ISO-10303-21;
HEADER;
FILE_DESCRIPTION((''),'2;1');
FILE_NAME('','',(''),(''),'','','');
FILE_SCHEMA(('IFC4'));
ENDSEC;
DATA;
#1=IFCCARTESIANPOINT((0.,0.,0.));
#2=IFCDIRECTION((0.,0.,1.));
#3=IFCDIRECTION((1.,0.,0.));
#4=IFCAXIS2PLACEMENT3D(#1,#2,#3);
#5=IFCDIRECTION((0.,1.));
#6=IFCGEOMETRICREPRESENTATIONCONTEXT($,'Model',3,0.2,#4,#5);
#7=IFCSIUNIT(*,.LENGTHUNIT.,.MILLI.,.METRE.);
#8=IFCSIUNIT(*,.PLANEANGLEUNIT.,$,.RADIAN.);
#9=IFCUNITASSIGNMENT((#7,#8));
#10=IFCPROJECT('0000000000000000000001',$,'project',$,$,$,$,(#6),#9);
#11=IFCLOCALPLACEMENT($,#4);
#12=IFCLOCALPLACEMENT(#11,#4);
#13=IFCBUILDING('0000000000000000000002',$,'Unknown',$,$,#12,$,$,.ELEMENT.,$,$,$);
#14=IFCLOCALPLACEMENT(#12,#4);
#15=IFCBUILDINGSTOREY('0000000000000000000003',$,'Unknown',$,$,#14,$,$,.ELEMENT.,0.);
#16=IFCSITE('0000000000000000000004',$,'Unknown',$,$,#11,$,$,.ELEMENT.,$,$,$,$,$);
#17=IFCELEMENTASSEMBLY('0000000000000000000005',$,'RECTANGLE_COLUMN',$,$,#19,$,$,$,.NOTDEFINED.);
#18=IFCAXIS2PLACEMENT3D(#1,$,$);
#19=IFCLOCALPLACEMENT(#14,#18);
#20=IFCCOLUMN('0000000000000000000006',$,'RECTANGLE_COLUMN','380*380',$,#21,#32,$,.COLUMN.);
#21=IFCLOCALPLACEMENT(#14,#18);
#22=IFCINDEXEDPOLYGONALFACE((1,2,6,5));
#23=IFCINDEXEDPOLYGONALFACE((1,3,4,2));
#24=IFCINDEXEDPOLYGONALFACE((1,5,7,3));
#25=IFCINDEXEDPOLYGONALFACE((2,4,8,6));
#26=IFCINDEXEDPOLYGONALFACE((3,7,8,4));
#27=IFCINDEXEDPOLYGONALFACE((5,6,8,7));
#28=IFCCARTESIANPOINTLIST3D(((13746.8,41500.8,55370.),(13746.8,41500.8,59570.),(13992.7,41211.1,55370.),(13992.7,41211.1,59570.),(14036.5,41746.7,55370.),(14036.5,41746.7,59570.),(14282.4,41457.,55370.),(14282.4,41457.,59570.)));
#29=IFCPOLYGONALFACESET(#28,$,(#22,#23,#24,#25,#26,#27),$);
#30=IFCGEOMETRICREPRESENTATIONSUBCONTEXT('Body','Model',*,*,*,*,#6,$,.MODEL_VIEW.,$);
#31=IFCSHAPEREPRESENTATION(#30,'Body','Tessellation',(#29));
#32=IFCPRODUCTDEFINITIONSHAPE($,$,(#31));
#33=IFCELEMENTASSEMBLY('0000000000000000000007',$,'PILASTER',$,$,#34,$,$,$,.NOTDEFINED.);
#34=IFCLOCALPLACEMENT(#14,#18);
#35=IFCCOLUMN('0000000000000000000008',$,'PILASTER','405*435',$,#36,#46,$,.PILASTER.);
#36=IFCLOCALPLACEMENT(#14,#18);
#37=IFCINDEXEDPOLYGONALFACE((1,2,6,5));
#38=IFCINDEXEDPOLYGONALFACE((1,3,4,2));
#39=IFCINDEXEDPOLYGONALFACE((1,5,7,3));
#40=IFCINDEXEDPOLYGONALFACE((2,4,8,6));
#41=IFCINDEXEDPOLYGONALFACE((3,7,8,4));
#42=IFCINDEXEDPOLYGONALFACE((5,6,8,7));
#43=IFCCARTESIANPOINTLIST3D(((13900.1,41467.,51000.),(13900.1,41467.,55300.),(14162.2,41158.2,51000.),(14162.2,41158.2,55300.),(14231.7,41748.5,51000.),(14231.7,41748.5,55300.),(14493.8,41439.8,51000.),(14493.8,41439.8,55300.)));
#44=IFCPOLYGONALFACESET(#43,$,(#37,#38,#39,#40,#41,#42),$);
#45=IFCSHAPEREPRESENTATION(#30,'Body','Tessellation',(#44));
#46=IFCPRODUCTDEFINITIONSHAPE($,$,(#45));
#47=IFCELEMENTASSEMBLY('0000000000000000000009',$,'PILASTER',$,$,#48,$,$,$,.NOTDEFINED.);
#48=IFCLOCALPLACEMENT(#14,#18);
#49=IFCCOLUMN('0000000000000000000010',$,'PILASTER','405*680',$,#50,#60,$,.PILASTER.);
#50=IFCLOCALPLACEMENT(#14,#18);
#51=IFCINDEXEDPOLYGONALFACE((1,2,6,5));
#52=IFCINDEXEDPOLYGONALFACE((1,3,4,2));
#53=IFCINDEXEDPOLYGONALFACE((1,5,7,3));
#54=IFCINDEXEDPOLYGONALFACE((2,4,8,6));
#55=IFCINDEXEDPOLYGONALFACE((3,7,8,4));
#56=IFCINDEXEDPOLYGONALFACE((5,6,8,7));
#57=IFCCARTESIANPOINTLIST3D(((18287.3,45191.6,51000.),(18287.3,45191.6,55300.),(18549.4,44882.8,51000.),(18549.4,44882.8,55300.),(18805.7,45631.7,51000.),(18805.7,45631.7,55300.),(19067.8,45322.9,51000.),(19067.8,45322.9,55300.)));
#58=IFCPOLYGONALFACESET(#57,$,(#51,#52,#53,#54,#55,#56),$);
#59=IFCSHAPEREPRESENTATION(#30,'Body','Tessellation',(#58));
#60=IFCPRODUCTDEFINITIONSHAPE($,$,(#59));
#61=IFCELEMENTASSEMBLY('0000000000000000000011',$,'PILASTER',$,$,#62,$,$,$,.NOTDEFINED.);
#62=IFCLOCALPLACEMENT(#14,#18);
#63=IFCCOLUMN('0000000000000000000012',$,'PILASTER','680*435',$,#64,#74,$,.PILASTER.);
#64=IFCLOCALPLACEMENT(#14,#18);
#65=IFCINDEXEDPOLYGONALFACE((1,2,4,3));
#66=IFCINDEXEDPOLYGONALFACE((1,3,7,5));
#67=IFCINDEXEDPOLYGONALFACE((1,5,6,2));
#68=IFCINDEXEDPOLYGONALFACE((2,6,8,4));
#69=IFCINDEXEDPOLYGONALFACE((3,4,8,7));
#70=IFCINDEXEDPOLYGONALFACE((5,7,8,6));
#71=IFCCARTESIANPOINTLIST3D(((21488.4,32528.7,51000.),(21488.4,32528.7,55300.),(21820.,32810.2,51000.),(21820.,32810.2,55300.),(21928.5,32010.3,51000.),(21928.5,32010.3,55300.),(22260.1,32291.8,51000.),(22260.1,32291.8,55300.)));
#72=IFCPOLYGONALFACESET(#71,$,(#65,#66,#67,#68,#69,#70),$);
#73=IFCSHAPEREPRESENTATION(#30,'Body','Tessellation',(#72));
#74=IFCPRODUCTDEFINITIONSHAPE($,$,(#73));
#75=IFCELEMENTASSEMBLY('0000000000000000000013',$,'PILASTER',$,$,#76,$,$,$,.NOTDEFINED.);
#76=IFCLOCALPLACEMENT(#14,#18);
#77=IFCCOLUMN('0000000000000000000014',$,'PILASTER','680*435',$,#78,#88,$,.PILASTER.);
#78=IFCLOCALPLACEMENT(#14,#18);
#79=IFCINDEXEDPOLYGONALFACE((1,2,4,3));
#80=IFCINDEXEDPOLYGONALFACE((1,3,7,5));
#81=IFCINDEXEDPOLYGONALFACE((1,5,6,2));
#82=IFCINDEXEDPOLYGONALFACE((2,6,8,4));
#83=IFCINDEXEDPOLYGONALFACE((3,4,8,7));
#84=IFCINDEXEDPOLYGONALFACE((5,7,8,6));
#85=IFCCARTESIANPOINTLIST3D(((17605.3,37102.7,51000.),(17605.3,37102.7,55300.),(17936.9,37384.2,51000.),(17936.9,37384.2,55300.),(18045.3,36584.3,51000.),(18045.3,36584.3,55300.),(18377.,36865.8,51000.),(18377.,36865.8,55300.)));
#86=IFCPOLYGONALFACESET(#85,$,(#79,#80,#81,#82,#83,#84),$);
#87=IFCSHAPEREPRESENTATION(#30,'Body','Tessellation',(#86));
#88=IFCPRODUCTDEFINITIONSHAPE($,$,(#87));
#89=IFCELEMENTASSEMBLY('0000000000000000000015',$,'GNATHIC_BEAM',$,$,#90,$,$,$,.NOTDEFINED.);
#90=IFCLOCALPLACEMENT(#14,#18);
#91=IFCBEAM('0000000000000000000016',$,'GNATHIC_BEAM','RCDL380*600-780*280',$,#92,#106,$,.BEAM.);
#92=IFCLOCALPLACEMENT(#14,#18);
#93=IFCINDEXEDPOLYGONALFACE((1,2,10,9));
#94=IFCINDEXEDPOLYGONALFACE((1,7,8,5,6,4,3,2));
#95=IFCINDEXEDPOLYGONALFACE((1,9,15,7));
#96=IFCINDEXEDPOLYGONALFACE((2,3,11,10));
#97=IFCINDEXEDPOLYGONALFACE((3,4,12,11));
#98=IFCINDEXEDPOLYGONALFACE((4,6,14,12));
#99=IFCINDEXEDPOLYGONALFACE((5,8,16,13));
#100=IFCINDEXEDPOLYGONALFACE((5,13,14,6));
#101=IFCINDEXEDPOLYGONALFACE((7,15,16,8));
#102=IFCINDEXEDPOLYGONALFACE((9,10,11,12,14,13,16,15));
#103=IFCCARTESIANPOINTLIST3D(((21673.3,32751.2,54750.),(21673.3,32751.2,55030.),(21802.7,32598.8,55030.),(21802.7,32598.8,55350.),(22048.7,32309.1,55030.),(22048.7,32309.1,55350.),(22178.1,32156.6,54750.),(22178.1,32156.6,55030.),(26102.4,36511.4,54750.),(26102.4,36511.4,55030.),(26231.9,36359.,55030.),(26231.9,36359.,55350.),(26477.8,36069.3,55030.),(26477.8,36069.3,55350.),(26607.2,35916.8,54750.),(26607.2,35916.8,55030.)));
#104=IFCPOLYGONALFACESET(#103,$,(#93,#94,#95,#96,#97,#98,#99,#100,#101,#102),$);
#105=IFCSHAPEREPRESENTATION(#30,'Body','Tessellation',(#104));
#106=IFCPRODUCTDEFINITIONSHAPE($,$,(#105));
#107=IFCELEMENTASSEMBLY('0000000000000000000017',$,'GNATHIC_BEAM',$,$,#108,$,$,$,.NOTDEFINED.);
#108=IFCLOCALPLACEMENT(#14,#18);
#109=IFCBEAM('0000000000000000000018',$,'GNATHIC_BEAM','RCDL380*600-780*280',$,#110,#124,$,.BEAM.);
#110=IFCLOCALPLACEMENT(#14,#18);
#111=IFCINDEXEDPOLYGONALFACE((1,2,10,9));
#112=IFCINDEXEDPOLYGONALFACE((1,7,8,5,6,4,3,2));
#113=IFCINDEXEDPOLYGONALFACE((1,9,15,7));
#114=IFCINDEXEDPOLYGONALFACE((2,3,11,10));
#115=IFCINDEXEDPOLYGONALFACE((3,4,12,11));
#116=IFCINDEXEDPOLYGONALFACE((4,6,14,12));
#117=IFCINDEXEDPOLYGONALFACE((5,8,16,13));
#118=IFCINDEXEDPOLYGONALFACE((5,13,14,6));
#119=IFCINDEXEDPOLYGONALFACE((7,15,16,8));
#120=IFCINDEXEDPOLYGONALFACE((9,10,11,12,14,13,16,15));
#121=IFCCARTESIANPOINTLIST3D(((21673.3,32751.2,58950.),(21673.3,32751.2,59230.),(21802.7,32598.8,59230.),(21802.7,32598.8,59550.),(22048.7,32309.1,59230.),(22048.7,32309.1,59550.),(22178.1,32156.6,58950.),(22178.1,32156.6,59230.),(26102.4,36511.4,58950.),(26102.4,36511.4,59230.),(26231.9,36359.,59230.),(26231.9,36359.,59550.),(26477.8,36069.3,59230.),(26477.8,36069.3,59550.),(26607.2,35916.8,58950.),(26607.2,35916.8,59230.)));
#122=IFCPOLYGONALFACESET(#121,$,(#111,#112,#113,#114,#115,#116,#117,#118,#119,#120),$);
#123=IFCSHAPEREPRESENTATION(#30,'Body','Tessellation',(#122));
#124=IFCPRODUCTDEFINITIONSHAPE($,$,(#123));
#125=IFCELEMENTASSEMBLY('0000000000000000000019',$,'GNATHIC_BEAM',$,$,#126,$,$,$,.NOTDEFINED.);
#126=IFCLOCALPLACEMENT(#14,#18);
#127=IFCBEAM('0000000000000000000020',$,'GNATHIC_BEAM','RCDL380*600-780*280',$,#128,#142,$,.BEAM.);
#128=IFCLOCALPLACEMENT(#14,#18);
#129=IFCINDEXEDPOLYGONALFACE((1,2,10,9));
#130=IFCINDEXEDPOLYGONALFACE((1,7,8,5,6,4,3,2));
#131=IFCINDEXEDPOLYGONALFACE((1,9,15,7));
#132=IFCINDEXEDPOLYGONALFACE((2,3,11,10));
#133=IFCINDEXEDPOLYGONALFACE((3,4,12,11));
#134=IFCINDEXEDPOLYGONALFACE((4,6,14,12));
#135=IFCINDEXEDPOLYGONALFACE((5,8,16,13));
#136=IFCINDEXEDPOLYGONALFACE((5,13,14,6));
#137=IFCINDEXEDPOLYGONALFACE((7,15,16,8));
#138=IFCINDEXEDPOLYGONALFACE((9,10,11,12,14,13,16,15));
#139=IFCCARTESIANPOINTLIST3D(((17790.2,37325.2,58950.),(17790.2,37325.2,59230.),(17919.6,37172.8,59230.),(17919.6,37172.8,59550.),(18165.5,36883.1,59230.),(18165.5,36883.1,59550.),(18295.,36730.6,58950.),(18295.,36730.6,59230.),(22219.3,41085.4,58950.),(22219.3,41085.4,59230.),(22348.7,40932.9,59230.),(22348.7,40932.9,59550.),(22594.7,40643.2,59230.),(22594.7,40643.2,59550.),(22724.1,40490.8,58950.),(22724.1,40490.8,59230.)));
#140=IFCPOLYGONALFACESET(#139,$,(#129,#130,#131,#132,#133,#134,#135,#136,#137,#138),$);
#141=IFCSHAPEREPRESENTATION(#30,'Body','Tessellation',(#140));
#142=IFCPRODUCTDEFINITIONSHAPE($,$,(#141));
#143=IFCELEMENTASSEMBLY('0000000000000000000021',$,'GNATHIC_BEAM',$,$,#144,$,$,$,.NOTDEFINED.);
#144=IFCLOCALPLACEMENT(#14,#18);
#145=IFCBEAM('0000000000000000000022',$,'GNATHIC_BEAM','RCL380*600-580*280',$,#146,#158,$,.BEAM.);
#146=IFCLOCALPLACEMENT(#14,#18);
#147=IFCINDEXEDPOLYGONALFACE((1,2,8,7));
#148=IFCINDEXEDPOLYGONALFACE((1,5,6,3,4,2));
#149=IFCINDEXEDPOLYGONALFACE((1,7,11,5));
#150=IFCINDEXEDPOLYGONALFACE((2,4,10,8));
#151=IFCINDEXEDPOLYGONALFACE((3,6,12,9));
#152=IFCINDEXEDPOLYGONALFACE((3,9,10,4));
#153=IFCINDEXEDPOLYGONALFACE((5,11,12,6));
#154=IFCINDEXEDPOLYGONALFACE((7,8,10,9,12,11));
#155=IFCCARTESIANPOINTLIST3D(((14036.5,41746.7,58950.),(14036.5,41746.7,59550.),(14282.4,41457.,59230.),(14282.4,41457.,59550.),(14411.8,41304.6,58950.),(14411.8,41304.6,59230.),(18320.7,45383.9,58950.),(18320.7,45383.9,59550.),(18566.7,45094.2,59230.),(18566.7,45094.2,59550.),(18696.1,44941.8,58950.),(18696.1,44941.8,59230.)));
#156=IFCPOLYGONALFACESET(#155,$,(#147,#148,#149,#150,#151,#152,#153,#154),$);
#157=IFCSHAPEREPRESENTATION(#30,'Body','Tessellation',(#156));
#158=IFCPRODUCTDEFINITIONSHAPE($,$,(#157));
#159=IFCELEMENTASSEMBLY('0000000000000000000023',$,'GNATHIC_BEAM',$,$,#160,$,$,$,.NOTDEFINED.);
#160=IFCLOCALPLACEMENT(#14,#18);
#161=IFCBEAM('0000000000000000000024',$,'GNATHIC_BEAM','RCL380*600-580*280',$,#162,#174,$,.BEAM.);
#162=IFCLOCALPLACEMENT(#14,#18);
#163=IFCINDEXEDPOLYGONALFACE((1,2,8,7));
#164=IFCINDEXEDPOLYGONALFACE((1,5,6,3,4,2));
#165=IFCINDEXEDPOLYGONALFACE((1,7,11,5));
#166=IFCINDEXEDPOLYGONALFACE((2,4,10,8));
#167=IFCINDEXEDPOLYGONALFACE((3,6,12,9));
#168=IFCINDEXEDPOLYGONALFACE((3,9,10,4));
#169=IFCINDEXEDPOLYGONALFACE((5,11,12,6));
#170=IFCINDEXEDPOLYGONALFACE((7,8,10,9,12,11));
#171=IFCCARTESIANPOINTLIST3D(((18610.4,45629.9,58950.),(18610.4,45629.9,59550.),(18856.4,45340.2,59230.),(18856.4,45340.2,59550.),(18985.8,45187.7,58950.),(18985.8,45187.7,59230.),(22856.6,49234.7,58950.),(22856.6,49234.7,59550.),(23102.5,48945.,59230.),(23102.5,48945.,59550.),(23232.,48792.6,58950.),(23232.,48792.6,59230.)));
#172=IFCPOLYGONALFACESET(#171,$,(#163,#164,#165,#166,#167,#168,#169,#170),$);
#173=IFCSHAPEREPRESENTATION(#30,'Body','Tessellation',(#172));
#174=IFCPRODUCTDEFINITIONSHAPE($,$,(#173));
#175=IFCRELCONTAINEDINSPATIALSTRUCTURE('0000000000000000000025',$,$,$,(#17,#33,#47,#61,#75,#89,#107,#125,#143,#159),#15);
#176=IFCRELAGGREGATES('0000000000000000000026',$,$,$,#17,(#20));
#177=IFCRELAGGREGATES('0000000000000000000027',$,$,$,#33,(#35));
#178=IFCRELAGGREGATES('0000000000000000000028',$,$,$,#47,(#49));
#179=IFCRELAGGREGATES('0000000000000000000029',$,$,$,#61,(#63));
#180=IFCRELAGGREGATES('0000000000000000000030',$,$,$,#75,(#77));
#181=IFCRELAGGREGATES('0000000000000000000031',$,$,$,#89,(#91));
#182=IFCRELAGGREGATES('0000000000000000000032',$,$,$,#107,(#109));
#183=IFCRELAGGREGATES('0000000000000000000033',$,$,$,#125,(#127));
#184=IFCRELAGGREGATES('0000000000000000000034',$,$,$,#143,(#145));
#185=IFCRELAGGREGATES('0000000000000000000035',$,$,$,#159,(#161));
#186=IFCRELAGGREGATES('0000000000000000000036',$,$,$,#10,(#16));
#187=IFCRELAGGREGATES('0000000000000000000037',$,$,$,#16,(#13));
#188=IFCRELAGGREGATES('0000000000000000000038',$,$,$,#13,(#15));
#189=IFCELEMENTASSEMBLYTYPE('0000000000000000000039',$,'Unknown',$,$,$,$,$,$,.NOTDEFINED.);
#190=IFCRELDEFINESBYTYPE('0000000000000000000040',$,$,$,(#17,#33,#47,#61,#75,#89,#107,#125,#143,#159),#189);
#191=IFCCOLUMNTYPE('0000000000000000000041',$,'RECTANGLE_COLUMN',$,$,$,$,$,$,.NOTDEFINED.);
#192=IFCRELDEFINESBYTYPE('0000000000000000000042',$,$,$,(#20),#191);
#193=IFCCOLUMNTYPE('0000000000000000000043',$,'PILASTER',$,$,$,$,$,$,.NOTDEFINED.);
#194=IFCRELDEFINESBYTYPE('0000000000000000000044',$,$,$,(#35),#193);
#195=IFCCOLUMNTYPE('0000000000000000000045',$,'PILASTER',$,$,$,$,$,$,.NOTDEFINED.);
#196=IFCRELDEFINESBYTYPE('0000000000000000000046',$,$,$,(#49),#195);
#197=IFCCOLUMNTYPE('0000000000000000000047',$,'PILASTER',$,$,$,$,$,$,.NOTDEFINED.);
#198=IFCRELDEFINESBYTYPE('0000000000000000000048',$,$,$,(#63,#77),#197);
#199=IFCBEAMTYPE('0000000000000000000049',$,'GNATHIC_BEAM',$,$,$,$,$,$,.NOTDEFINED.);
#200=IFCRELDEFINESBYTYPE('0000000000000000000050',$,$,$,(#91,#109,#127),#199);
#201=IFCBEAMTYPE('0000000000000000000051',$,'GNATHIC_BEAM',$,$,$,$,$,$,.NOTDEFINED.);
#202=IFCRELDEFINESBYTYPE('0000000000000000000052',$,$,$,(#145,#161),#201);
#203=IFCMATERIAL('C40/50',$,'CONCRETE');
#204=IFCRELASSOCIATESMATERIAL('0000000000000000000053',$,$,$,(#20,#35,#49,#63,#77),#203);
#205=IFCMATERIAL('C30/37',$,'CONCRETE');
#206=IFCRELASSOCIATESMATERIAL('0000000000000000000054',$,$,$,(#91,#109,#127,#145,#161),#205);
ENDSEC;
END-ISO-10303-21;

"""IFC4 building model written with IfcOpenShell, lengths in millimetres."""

from ifc_helpers import new_model, si_unit, direction, frame, origin_with_axes, origin_2d_with_axis, place, context, subcontext, project, spatial, polyline, rectangle, outline, extrude, material, material_profile, profile_set, profile_usage, type_object, element, aggregate, save


model = new_model("IFC4")

# Units and contexts
model_context = context("Model", 3, precision=0.2, world=origin_with_axes(), true_north=direction((0.0, 1.0)))
body_context = subcontext(model_context, "Body", "Model", "MODEL_VIEW")
ifc_project = project(units=[si_unit("LENGTHUNIT", "METRE", prefix="MILLI"), si_unit("PLANEANGLEUNIT", "RADIAN")], contexts=[model_context])

# Site, building, storey
site_placement = place(None, origin_with_axes())
site = spatial("IfcSite", under=ifc_project, at=site_placement, Name="Unknown", CompositionType="ELEMENT")
building_placement = place(site_placement, origin_with_axes())
building = spatial("IfcBuilding", under=site, at=building_placement, Name="Unknown", CompositionType="ELEMENT")
storey_placement = place(building_placement, origin_with_axes())
storey = spatial("IfcBuildingStorey", under=building, at=storey_placement, Name="Unknown", CompositionType="ELEMENT", Elevation=0.0)

# Shared definitions
element_assembly_type = type_object("IfcElementAssemblyType", Name="Unknown", PredefinedType="NOTDEFINED")
ifc_material_1 = material(Name="C40/50", Category="CONCRETE")

# Element assemblies, columns
ifc_material_profile_1 = material_profile(ifc_material_1, rectangle(XDim=380.0, YDim=380.0, at=origin_2d_with_axis()), Name="380*380")
ifc_profile_set_1 = profile_set([ifc_material_profile_1])
ifc_profile_usage_1 = profile_usage(ifc_profile_set_1, cardinal=5)
column_type_1 = type_object("IfcColumnType", Name="RECTANGLE_COLUMN")
assembly_1_placement = place(storey_placement, frame((14014.6, 41478.9, 55370.0), z_axis=(-0.762329, -0.64719, 0.0), x_axis=(0.0, 0.0, 1.0)))
assembly_1 = element("IfcElementAssembly", 1, at=assembly_1_placement, inside=storey, type_object=element_assembly_type, Name="RECTANGLE_COLUMN", PredefinedType="NOTDEFINED")
column_1_placement = place(assembly_1_placement, origin_with_axes())
column_1 = element("IfcColumn", 2, at=column_1_placement, type_object=column_type_1, material=ifc_profile_usage_1, Name="RECTANGLE_COLUMN", Description="380*380", PredefinedType="COLUMN", context=body_context, shape_type="SolidModel", body=[
    extrude(rectangle(XDim=380.0, YDim=380.0, at=origin_2d_with_axis()), frame((0.0, 0.0, 0.0), z_axis=(-1.0, 0.0, 0.0), x_axis=(0.0, 0.0, 1.0)), (0.0, 0.0, -1.0), 4200.0),
])
aggregate(assembly_1, [column_1])
assembly_2_placement = place(storey_placement, frame((14197.0, 41453.4, 51000.0), z_axis=(-0.762329, -0.64719, 0.0), x_axis=(0.0, 0.0, 1.0)))
assembly_2 = element("IfcElementAssembly", 3, at=assembly_2_placement, inside=storey, type_object=element_assembly_type, Name="PILASTER", PredefinedType="NOTDEFINED")
ifc_material_profile_2 = material_profile(ifc_material_1, rectangle(XDim=435.0, YDim=405.0, at=origin_2d_with_axis()), Name="405*435")
ifc_profile_set_2 = profile_set([ifc_material_profile_2])
ifc_profile_usage_2 = profile_usage(ifc_profile_set_2, cardinal=7)
column_type_2 = type_object("IfcColumnType", Name="PILASTER")
column_2_placement = place(assembly_2_placement, origin_with_axes())
column_2 = element("IfcColumn", 4, at=column_2_placement, type_object=column_type_2, material=ifc_profile_usage_2, Name="PILASTER", Description="405*435", PredefinedType="PILASTER", context=body_context, shape_type="SolidModel", body=[
    extrude(rectangle(XDim=435.0, YDim=405.0, at=origin_2d_with_axis()), frame((0.0, 0.0, 0.0), z_axis=(-1.0, 0.0, 0.0), x_axis=(0.0, 0.0, 1.0)), (0.0, 0.0, -1.0), 4300.0),
])
aggregate(assembly_2, [column_2])
assembly_3_placement = place(storey_placement, frame((18677.5, 45257.2, 51000.0), z_axis=(-0.762329, -0.64719, 0.0), x_axis=(0.0, 0.0, 1.0)))
assembly_3 = element("IfcElementAssembly", 5, at=assembly_3_placement, inside=storey, type_object=element_assembly_type, Name="PILASTER", PredefinedType="NOTDEFINED")
ifc_material_profile_3 = material_profile(ifc_material_1, rectangle(XDim=680.0, YDim=405.0, at=origin_2d_with_axis()), Name="405*680")
ifc_profile_set_3 = profile_set([ifc_material_profile_3])
ifc_profile_usage_3 = profile_usage(ifc_profile_set_3, cardinal=4)
column_type_3 = type_object("IfcColumnType", Name="PILASTER")
column_3_placement = place(assembly_3_placement, origin_with_axes())
column_3 = element("IfcColumn", 6, at=column_3_placement, type_object=column_type_3, material=ifc_profile_usage_3, Name="PILASTER", Description="405*680", PredefinedType="PILASTER", context=body_context, shape_type="SolidModel", body=[
    extrude(rectangle(XDim=680.0, YDim=405.0, at=origin_2d_with_axis()), frame((0.0, 0.0, 0.0), z_axis=(-1.0, 0.0, 0.0), x_axis=(0.0, 0.0, 1.0)), (0.0, 0.0, -1.0), 4300.0),
])
aggregate(assembly_3, [column_3])
assembly_4_placement = place(storey_placement, frame((21874.2, 32410.3, 51000.0), z_axis=(-0.762329, -0.64719, 0.0), x_axis=(0.0, 0.0, 1.0)))
assembly_4 = element("IfcElementAssembly", 7, at=assembly_4_placement, inside=storey, type_object=element_assembly_type, Name="PILASTER", PredefinedType="NOTDEFINED")
ifc_material_profile_4 = material_profile(ifc_material_1, rectangle(XDim=435.0, YDim=680.0, at=origin_2d_with_axis()), Name="680*435")
ifc_profile_set_4 = profile_set([ifc_material_profile_4])
ifc_profile_usage_4 = profile_usage(ifc_profile_set_4, cardinal=8)
column_type_4 = type_object("IfcColumnType", Name="PILASTER")
column_4_placement = place(assembly_4_placement, origin_with_axes())
column_4 = element("IfcColumn", 8, at=column_4_placement, type_object=column_type_4, material=ifc_profile_usage_4, Name="PILASTER", Description="680*435", PredefinedType="PILASTER", context=body_context, shape_type="SolidModel", body=[
    extrude(rectangle(XDim=435.0, YDim=680.0, at=origin_2d_with_axis()), frame((0.0, 0.0, 0.0), z_axis=(-1.0, 0.0, 0.0), x_axis=(0.0, 0.0, 1.0)), (0.0, 0.0, -1.0), 4300.0),
])
aggregate(assembly_4, [column_4])
assembly_5_placement = place(storey_placement, frame((17991.1, 36984.2, 51000.0), z_axis=(-0.762329, -0.64719, 0.0), x_axis=(0.0, 0.0, 1.0)))
assembly_5 = element("IfcElementAssembly", 9, at=assembly_5_placement, inside=storey, type_object=element_assembly_type, Name="PILASTER", PredefinedType="NOTDEFINED")
column_5_placement = place(assembly_5_placement, origin_with_axes())
column_5 = element("IfcColumn", 10, at=column_5_placement, type_object=column_type_4, material=ifc_profile_usage_4, Name="PILASTER", Description="680*435", PredefinedType="PILASTER", context=body_context, shape_type="SolidModel", body=[
    extrude(rectangle(XDim=435.0, YDim=680.0, at=origin_2d_with_axis()), frame((0.0, 0.0, 0.0), z_axis=(-1.0, 0.0, 0.0), x_axis=(0.0, 0.0, 1.0)), (0.0, 0.0, -1.0), 4300.0),
])
aggregate(assembly_5, [column_5])

# Element assemblies, beams
assembly_6_placement = place(storey_placement, frame((21925.7, 32453.9, 55050.0), z_axis=(0.64719, -0.762329, 0.0), x_axis=(0.762329, 0.64719, 0.0)))
assembly_6 = element("IfcElementAssembly", 11, at=assembly_6_placement, inside=storey, type_object=element_assembly_type, Name="GNATHIC_BEAM", PredefinedType="NOTDEFINED")
ifc_material_2 = material(Name="C30/37", Category="CONCRETE")
ifc_material_profile_5 = material_profile(ifc_material_2, outline(polyline([(-390.0, -300.0), (390.0, -300.0), (390.0, -20.0), (190.0, -20.0), (190.0, 300.0), (-190.0, 300.0), (-190.0, -20.0), (-390.0, -20.0), (-390.0, -300.0)])), Name="RCDL380*600-780*280")
ifc_profile_set_5 = profile_set([ifc_material_profile_5])
ifc_profile_usage_5 = profile_usage(ifc_profile_set_5, cardinal=2)
beam_type_1 = type_object("IfcBeamType", Name="GNATHIC_BEAM")
beam_1_placement = place(assembly_6_placement, origin_with_axes())
beam_1 = element("IfcBeam", 12, at=beam_1_placement, type_object=beam_type_1, material=ifc_profile_usage_5, Name="GNATHIC_BEAM", Description="RCDL380*600-780*280", PredefinedType="BEAM", context=body_context, shape_type="SolidModel", body=[
    extrude(outline(polyline([(-390.0, -300.0), (390.0, -300.0), (390.0, -20.0), (190.0, -20.0), (190.0, 300.0), (-190.0, 300.0), (-190.0, -20.0), (-390.0, -20.0), (-390.0, -300.0)])), frame((0.0, 0.0, 0.0), z_axis=(-1.0, 0.0, 0.0), x_axis=(0.0, 0.0, 1.0)), (0.0, 0.0, -1.0), 5810.0),
])
aggregate(assembly_6, [beam_1])
assembly_7_placement = place(storey_placement, frame((21925.7, 32453.9, 59250.0), z_axis=(0.64719, -0.762329, 0.0), x_axis=(0.762329, 0.64719, 0.0)))
assembly_7 = element("IfcElementAssembly", 13, at=assembly_7_placement, inside=storey, type_object=element_assembly_type, Name="GNATHIC_BEAM", PredefinedType="NOTDEFINED")
beam_2_placement = place(assembly_7_placement, origin_with_axes())
beam_2 = element("IfcBeam", 14, at=beam_2_placement, type_object=beam_type_1, material=ifc_profile_usage_5, Name="GNATHIC_BEAM", Description="RCDL380*600-780*280", PredefinedType="BEAM", context=body_context, shape_type="SolidModel", body=[
    extrude(outline(polyline([(-390.0, -300.0), (390.0, -300.0), (390.0, -20.0), (190.0, -20.0), (190.0, 300.0), (-190.0, 300.0), (-190.0, -20.0), (-390.0, -20.0), (-390.0, -300.0)])), frame((0.0, 0.0, 0.0), z_axis=(-1.0, 0.0, 0.0), x_axis=(0.0, 0.0, 1.0)), (0.0, 0.0, -1.0), 5810.0),
])
aggregate(assembly_7, [beam_2])
assembly_8_placement = place(storey_placement, frame((18042.6, 37027.9, 59250.0), z_axis=(0.64719, -0.762329, 0.0), x_axis=(0.762329, 0.64719, 0.0)))
assembly_8 = element("IfcElementAssembly", 15, at=assembly_8_placement, inside=storey, type_object=element_assembly_type, Name="GNATHIC_BEAM", PredefinedType="NOTDEFINED")
beam_3_placement = place(assembly_8_placement, origin_with_axes())
beam_3 = element("IfcBeam", 16, at=beam_3_placement, type_object=beam_type_1, material=ifc_profile_usage_5, Name="GNATHIC_BEAM", Description="RCDL380*600-780*280", PredefinedType="BEAM", context=body_context, shape_type="SolidModel", body=[
    extrude(outline(polyline([(-390.0, -300.0), (390.0, -300.0), (390.0, -20.0), (190.0, -20.0), (190.0, 300.0), (-190.0, 300.0), (-190.0, -20.0), (-390.0, -20.0), (-390.0, -300.0)])), frame((0.0, 0.0, 0.0), z_axis=(-1.0, 0.0, 0.0), x_axis=(0.0, 0.0, 1.0)), (0.0, 0.0, -1.0), 5810.0),
])
aggregate(assembly_8, [beam_3])
assembly_9_placement = place(storey_placement, frame((14159.4, 41601.9, 59250.0), z_axis=(0.64719, -0.762329, 0.0), x_axis=(0.762329, 0.64719, 0.0)))
assembly_9 = element("IfcElementAssembly", 17, at=assembly_9_placement, inside=storey, type_object=element_assembly_type, Name="GNATHIC_BEAM", PredefinedType="NOTDEFINED")
ifc_material_profile_6 = material_profile(ifc_material_2, outline(polyline([(-190.0, -300.0), (390.0, -300.0), (390.0, -20.0), (190.0, -20.0), (190.0, 300.0), (-190.0, 300.0), (-190.0, -300.0)])), Name="RCL380*600-580*280")
ifc_profile_set_6 = profile_set([ifc_material_profile_6])
ifc_profile_usage_6 = profile_usage(ifc_profile_set_6, cardinal=2)
beam_type_2 = type_object("IfcBeamType", Name="GNATHIC_BEAM")
beam_4_placement = place(assembly_9_placement, origin_with_axes())
beam_4 = element("IfcBeam", 18, at=beam_4_placement, type_object=beam_type_2, material=ifc_profile_usage_6, Name="GNATHIC_BEAM", Description="RCL380*600-580*280", PredefinedType="BEAM", context=body_context, shape_type="SolidModel", body=[
    extrude(outline(polyline([(-190.0, -300.0), (390.0, -300.0), (390.0, -20.0), (190.0, -20.0), (190.0, 300.0), (-190.0, 300.0), (-190.0, -300.0)])), frame((0.0, 0.0, 0.0), z_axis=(-1.0, 0.0, 0.0), x_axis=(0.0, 0.0, 1.0)), (0.0, 0.0, -1.0), 5620.0),
])
aggregate(assembly_9, [beam_4])
assembly_10_placement = place(storey_placement, frame((18733.4, 45485.0, 59250.0), z_axis=(0.64719, -0.762329, 0.0), x_axis=(0.762329, 0.64719, 0.0)))
assembly_10 = element("IfcElementAssembly", 19, at=assembly_10_placement, inside=storey, type_object=element_assembly_type, Name="GNATHIC_BEAM", PredefinedType="NOTDEFINED")
beam_5_placement = place(assembly_10_placement, origin_with_axes())
beam_5 = element("IfcBeam", 20, at=beam_5_placement, type_object=beam_type_2, material=ifc_profile_usage_6, Name="GNATHIC_BEAM", Description="RCL380*600-580*280", PredefinedType="BEAM", context=body_context, shape_type="SolidModel", body=[
    extrude(outline(polyline([(-190.0, -300.0), (390.0, -300.0), (390.0, -20.0), (190.0, -20.0), (190.0, 300.0), (-190.0, 300.0), (-190.0, -300.0)])), frame((0.0, 0.0, 0.0), z_axis=(-1.0, 0.0, 0.0), x_axis=(0.0, 0.0, 1.0)), (0.0, 0.0, -1.0), 5570.0),
])
aggregate(assembly_10, [beam_5])

save(model, "model.ifc")
